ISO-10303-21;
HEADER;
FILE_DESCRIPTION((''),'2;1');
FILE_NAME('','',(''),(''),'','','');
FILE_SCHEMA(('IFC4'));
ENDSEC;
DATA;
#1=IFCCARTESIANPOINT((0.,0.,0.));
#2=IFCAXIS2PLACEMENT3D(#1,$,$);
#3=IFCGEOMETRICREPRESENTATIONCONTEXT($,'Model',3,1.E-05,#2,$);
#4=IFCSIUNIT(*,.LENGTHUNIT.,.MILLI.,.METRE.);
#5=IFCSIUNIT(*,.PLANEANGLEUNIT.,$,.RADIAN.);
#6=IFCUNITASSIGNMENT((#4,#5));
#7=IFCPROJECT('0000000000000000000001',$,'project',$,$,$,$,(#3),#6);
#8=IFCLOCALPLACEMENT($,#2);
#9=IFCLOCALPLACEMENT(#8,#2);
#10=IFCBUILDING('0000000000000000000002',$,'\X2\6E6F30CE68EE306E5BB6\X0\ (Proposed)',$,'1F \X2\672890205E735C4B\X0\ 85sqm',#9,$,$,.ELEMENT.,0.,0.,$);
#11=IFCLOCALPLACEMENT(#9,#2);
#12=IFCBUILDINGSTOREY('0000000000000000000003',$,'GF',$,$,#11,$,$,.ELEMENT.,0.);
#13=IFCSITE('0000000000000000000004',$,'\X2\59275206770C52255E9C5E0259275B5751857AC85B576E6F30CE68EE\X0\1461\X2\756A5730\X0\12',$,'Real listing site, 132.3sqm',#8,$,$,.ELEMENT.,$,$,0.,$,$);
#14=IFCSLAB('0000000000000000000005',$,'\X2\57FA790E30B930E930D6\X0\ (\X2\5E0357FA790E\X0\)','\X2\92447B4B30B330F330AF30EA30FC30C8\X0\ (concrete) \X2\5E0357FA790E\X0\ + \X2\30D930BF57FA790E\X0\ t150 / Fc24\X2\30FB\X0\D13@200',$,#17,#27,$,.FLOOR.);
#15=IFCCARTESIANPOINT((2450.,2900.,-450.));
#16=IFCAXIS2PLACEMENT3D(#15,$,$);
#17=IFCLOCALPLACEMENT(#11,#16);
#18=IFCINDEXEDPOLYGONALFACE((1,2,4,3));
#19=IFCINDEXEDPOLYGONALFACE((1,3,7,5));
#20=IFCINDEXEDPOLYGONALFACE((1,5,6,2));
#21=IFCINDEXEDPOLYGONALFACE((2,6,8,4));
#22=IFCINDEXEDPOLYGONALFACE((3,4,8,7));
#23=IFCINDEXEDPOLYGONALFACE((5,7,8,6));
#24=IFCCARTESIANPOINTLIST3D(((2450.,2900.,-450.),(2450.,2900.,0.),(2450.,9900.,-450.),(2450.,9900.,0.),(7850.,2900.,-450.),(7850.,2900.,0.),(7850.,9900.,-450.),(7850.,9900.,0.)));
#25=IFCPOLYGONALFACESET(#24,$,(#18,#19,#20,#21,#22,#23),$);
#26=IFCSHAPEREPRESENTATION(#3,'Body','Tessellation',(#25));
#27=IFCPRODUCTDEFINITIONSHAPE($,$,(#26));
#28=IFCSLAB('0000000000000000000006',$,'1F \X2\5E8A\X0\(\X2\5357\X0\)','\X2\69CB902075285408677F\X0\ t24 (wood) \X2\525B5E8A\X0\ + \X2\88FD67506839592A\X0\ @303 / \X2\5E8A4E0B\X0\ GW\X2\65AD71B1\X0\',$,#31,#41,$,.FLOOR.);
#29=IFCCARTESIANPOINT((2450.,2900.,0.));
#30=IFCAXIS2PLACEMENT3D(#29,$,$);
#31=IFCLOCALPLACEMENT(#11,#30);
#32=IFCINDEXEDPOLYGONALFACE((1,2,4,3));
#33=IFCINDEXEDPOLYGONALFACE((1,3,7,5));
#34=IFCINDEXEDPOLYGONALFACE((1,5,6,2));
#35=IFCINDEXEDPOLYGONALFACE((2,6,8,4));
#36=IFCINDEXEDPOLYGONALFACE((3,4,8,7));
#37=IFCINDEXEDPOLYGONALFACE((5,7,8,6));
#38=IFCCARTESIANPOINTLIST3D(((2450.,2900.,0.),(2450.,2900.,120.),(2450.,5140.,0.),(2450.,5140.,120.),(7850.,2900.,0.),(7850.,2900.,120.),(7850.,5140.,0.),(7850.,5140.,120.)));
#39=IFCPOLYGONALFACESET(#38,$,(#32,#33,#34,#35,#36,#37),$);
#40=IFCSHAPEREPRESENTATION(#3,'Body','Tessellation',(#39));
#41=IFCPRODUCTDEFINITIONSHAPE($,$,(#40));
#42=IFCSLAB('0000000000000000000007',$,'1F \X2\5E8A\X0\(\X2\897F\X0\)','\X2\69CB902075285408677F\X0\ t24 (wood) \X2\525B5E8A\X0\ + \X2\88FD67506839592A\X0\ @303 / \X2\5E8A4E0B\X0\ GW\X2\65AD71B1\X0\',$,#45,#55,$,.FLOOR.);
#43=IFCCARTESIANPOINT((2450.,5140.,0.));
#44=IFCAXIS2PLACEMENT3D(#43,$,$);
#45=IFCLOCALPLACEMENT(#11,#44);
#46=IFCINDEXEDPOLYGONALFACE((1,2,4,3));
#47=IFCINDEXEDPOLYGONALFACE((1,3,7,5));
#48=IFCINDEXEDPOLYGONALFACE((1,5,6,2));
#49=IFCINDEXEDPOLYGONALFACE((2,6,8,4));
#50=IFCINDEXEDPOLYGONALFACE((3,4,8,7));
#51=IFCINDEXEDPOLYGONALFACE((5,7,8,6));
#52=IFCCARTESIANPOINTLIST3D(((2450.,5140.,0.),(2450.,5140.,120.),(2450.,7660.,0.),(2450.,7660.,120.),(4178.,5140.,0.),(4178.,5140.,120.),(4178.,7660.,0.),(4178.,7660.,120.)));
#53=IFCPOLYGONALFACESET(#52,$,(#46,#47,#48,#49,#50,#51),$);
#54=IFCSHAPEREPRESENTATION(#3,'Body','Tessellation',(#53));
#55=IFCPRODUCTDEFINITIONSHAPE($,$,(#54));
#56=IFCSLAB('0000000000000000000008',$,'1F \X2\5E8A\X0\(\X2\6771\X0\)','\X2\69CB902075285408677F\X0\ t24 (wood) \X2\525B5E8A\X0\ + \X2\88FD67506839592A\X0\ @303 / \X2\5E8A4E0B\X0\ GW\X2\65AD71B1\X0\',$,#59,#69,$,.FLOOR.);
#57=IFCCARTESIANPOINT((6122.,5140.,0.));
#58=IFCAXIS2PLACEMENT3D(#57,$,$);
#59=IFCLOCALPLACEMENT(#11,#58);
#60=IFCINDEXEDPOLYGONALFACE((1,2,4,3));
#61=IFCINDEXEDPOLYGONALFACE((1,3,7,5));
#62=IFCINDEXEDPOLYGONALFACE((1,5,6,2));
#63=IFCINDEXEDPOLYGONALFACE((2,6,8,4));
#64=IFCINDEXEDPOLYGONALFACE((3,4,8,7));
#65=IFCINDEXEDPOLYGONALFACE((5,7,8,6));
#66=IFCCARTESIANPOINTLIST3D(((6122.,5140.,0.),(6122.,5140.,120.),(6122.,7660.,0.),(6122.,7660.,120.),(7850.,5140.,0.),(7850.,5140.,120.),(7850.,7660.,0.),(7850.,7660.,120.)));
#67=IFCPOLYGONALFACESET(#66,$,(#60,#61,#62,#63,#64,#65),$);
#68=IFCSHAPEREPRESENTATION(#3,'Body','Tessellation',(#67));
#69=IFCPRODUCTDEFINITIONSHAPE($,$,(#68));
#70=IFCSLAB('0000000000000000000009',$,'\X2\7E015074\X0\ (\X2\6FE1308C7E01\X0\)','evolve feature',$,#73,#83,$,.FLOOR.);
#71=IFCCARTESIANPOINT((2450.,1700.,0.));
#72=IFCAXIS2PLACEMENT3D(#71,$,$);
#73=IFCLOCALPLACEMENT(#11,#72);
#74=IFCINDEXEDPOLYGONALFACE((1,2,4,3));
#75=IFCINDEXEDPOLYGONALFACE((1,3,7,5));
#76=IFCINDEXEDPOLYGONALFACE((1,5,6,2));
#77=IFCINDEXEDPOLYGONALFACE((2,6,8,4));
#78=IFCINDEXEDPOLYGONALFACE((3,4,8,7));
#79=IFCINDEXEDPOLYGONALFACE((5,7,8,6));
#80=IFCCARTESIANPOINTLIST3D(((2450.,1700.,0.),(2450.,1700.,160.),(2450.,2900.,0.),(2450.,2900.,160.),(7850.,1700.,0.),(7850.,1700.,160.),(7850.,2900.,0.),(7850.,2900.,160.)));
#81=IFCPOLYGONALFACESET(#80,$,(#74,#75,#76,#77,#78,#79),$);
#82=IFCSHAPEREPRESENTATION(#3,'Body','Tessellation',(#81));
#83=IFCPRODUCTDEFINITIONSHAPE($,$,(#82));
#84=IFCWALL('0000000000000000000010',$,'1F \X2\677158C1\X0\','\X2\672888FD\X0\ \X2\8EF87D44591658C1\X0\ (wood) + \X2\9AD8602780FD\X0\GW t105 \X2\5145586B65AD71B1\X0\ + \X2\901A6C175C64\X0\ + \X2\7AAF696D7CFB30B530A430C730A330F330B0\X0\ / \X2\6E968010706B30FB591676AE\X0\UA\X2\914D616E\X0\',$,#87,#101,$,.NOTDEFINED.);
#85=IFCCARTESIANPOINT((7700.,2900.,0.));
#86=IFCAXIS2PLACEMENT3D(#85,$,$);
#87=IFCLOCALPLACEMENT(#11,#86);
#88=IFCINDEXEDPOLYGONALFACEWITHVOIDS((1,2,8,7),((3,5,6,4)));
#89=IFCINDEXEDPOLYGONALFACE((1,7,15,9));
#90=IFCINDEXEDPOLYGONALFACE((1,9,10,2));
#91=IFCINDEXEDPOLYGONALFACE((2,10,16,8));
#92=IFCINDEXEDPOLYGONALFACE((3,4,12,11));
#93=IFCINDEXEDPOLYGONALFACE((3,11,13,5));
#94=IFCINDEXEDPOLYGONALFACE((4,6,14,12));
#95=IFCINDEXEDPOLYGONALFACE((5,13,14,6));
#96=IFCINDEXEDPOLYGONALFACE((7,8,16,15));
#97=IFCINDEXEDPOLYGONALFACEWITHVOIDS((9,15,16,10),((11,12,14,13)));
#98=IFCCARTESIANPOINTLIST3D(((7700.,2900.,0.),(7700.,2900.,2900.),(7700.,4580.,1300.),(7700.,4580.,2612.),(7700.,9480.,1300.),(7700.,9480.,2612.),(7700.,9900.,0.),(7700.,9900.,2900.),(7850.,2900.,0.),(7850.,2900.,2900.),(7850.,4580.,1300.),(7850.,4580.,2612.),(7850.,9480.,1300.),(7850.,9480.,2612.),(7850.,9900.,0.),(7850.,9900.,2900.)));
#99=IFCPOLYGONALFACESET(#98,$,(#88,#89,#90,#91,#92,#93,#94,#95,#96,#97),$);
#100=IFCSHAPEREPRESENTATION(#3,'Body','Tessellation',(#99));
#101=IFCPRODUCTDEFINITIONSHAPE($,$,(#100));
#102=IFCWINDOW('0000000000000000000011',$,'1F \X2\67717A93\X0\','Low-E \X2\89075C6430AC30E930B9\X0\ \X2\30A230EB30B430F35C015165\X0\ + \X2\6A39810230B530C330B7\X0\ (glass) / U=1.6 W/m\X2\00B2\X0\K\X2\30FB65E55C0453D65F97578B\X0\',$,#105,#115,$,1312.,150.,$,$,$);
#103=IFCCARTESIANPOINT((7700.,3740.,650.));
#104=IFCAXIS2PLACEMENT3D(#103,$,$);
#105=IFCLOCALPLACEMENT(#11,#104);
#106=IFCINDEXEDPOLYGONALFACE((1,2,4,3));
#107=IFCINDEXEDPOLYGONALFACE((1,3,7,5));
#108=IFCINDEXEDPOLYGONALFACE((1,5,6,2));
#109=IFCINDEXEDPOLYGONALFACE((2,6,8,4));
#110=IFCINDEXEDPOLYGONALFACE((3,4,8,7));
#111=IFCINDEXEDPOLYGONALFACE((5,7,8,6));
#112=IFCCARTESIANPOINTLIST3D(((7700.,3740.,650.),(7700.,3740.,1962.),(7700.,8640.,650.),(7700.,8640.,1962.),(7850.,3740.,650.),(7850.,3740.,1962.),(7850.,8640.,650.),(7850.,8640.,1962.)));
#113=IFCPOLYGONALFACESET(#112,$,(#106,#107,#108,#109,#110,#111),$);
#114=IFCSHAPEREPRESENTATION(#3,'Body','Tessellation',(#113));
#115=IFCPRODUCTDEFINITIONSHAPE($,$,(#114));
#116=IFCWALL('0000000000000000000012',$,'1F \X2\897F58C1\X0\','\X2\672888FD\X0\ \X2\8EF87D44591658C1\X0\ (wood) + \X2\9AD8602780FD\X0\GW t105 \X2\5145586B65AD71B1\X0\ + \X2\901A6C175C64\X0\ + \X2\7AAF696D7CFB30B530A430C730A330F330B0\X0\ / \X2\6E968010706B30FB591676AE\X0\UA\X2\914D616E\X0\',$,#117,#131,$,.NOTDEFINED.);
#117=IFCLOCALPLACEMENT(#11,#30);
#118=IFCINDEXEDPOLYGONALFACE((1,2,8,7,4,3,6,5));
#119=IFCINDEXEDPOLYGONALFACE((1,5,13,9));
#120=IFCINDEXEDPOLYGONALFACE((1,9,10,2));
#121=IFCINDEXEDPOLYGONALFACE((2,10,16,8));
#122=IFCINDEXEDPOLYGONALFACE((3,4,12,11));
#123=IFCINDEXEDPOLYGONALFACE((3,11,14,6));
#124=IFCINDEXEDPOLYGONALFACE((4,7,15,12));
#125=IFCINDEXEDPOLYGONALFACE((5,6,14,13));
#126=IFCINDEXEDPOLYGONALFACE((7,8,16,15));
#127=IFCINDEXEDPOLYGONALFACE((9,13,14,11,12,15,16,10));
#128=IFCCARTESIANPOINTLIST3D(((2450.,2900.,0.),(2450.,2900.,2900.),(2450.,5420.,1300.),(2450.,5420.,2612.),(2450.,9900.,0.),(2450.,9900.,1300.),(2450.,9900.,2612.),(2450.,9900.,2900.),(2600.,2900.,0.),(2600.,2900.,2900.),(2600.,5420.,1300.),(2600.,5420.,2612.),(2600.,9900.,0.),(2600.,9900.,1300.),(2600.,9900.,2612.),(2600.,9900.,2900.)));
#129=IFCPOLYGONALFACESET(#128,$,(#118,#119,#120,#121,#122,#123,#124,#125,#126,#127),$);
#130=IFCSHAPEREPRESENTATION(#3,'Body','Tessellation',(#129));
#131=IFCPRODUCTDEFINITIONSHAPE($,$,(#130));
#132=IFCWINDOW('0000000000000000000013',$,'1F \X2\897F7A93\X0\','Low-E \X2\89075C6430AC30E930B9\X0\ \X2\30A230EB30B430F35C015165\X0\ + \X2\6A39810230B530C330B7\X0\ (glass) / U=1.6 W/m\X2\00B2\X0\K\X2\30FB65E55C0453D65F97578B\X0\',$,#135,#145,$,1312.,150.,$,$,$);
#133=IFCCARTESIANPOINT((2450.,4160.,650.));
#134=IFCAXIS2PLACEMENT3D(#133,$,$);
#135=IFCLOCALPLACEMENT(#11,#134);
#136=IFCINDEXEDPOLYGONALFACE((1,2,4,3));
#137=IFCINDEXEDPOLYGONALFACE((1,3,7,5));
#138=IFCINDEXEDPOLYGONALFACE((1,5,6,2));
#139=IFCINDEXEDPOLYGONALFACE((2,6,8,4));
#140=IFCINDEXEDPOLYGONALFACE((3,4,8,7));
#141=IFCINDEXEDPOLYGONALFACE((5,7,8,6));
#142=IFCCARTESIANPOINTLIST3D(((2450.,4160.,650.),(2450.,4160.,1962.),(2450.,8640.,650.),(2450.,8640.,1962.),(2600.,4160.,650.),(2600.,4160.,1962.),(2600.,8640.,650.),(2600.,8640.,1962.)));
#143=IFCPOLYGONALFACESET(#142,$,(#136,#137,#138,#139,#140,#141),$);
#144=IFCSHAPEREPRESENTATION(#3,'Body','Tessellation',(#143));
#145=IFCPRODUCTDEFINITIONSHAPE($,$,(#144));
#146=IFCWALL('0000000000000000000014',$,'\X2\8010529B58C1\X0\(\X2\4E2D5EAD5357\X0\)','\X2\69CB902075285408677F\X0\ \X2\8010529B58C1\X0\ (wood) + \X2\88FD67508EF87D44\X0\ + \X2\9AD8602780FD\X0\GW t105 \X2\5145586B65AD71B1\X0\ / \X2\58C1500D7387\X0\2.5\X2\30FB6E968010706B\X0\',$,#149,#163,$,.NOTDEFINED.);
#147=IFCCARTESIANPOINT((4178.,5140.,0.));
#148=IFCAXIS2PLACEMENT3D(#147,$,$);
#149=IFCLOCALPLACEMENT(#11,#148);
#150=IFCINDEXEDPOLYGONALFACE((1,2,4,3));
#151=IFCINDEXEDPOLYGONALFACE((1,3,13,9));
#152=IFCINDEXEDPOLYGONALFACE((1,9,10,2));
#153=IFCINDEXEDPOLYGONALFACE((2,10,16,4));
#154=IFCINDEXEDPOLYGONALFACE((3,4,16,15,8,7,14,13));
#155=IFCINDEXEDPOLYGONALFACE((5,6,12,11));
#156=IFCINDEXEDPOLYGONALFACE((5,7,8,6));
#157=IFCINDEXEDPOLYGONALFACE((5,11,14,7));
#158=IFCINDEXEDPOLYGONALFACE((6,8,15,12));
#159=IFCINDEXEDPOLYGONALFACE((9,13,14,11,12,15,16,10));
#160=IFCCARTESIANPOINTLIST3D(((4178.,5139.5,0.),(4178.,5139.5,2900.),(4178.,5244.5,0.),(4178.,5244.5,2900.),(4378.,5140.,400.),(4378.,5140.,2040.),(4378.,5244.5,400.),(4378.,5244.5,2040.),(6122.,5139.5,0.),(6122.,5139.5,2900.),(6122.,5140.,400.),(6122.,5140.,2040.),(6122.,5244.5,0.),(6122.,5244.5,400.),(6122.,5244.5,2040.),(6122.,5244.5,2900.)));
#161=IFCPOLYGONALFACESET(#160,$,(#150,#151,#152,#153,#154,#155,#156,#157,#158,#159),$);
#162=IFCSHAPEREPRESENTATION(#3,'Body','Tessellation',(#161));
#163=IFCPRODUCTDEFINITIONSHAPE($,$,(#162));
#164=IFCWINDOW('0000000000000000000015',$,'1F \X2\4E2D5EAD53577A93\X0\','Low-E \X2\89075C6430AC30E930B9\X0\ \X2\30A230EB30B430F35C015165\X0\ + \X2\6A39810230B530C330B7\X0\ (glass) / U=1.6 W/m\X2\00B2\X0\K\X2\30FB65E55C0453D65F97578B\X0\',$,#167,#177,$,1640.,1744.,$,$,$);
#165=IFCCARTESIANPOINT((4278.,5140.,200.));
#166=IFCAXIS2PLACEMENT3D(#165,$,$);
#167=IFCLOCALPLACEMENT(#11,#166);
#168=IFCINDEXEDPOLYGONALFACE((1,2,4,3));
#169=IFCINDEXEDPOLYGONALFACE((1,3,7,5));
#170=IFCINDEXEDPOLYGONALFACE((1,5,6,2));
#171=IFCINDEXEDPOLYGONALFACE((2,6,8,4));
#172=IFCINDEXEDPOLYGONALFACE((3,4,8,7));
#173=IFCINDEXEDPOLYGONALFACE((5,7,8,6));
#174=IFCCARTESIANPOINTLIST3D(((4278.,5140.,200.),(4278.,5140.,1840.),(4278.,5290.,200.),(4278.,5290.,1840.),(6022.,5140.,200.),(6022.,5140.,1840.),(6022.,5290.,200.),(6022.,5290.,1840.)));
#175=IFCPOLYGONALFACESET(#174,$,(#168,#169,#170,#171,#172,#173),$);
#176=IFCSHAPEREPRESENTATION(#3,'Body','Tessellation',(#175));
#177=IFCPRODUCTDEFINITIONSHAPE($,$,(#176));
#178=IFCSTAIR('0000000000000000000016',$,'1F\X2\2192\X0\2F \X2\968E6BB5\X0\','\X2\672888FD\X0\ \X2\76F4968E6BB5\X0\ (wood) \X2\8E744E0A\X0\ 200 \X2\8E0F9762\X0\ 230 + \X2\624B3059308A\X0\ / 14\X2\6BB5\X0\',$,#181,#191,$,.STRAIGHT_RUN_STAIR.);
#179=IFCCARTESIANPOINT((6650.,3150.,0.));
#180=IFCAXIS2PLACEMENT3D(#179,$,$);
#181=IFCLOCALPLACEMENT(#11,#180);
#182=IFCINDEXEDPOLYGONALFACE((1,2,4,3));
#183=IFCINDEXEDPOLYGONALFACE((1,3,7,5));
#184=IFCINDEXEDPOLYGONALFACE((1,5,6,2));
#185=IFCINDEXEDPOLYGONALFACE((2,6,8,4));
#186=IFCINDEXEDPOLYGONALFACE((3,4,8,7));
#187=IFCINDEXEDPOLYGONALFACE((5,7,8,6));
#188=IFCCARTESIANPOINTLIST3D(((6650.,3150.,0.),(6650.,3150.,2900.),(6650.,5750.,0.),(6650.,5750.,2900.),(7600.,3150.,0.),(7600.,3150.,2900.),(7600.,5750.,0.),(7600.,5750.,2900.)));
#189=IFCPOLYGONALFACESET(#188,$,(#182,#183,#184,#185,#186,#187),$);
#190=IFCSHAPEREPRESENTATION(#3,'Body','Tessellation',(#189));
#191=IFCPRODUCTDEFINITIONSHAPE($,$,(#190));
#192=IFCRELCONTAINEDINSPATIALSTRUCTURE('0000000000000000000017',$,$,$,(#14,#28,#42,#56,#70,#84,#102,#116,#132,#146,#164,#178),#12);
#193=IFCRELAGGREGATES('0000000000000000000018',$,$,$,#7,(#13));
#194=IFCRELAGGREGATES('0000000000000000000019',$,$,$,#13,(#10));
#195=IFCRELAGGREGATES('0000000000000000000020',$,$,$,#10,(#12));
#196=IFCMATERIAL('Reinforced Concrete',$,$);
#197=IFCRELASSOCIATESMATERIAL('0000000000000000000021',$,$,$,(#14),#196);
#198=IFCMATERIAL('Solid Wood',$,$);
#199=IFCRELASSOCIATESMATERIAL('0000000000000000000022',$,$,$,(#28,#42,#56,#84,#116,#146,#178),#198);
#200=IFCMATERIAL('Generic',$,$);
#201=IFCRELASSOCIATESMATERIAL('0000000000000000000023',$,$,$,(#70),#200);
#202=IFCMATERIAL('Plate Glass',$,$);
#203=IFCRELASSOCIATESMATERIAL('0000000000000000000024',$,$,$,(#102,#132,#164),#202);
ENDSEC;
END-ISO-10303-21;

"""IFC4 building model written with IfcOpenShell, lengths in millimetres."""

from ifc_helpers import new_model, si_unit, frame, frame_2d, origin, place, context, project, spatial, rectangle, extrude, material, element, fill, save


model = new_model("IFC4")

# Units and contexts
model_context = context("Model", 3, precision=1e-05, world=origin())
ifc_project = project(units=[si_unit("LENGTHUNIT", "METRE", prefix="MILLI"), si_unit("PLANEANGLEUNIT", "RADIAN")], contexts=[model_context])

# Site, building, storey
site_placement = place(None, origin())
site = spatial("IfcSite", under=ifc_project, at=site_placement, Name="大分県別府市大字内竈字湯ノ森1461番地12", ObjectType="Real listing site, 132.3sqm", CompositionType="ELEMENT", RefElevation=0.0)
building_placement = place(site_placement, origin())
building = spatial("IfcBuilding", under=site, at=building_placement, Name="湯ノ森の家 (Proposed)", ObjectType="1F 木造平屋 85sqm", CompositionType="ELEMENT", ElevationOfRefHeight=0.0, ElevationOfTerrain=0.0)
storey_placement = place(building_placement, origin())
storey = spatial("IfcBuildingStorey", under=building, at=storey_placement, Name="GF", CompositionType="ELEMENT", Elevation=0.0)

# Slabs
ifc_material_1 = material(Name="Reinforced Concrete")
slab_1_placement = place(storey_placement, frame((2450.0, 2900.0, -450.0)))
element("IfcSlab", 1, at=slab_1_placement, inside=storey, material=ifc_material_1, Name="基礎スラブ (布基礎)", Description="鉄筋コンクリート (concrete) 布基礎 + ベタ基礎 t150 / Fc24・D13@200", PredefinedType="FLOOR", context=model_context, shape_type="SweptSolid", body=[
    extrude(rectangle(XDim=5400.0, YDim=7000.0, at=frame_2d((2700.0, 3500.0))), frame((2450.0, 2900.0, -450.0)), (0.0, 0.0, 1.0), 450.0),
])
ifc_material_2 = material(Name="Solid Wood")
slab_2_placement = place(storey_placement, frame((2450.0, 2900.0, 0.0)))
element("IfcSlab", 2, at=slab_2_placement, inside=storey, material=ifc_material_2, Name="1F 床(南)", Description="構造用合板 t24 (wood) 剛床 + 製材根太 @303 / 床下 GW断熱", PredefinedType="FLOOR", context=model_context, shape_type="SweptSolid", body=[
    extrude(rectangle(XDim=5400.0, YDim=2240.0, at=frame_2d((2700.0, 1120.0))), frame((2450.0, 2900.0, 0.0)), (0.0, 0.0, 1.0), 120.0),
])
slab_3_placement = place(storey_placement, frame((2450.0, 5140.0, 0.0)))
element("IfcSlab", 3, at=slab_3_placement, inside=storey, material=ifc_material_2, Name="1F 床(西)", Description="構造用合板 t24 (wood) 剛床 + 製材根太 @303 / 床下 GW断熱", PredefinedType="FLOOR", context=model_context, shape_type="SweptSolid", body=[
    extrude(rectangle(XDim=1728.0, YDim=2520.0, at=frame_2d((864.0, 1260.0))), frame((2450.0, 5140.0, 0.0)), (0.0, 0.0, 1.0), 120.0),
])
slab_4_placement = place(storey_placement, frame((6122.0, 5140.0, 0.0)))
element("IfcSlab", 4, at=slab_4_placement, inside=storey, material=ifc_material_2, Name="1F 床(東)", Description="構造用合板 t24 (wood) 剛床 + 製材根太 @303 / 床下 GW断熱", PredefinedType="FLOOR", context=model_context, shape_type="SweptSolid", body=[
    extrude(rectangle(XDim=1728.0, YDim=2520.0, at=frame_2d((864.0, 1260.0))), frame((6122.0, 5140.0, 0.0)), (0.0, 0.0, 1.0), 120.0),
])
ifc_material_3 = material(Name="Generic")
slab_5_placement = place(storey_placement, frame((2450.0, 1700.0, 0.0)))
element("IfcSlab", 5, at=slab_5_placement, inside=storey, material=ifc_material_3, Name="縁側 (濡れ縁)", Description="evolve feature", PredefinedType="FLOOR", context=model_context, shape_type="SweptSolid", body=[
    extrude(rectangle(XDim=5400.0, YDim=1200.0, at=frame_2d((2700.0, 600.0))), frame((2450.0, 1700.0, 0.0)), (0.0, 0.0, 1.0), 160.0),
])

# Shared definitions
ifc_material_4 = material(Name="Plate Glass")

# Walls, openings, windows
wall_1_placement = place(storey_placement, frame((7700.0, 2900.0, 0.0)))
wall_1 = element("IfcWall", 6, at=wall_1_placement, inside=storey, material=ifc_material_2, Name="1F 東壁", Description="木製 軸組外壁 (wood) + 高性能GW t105 充填断熱 + 通気層 + 窯業系サイディング / 準耐火・外皮UA配慮", PredefinedType="NOTDEFINED", context=model_context, shape_type="SweptSolid", body=[
    extrude(rectangle(XDim=150.0, YDim=7000.0, at=frame_2d((75.0, 3500.0))), frame((7700.0, 2900.0, 0.0)), (0.0, 0.0, 1.0), 2900.0),
])
opening_1_placement = place(storey_placement, frame((7700.0, 3740.0, 650.0)))
opening_1 = element("IfcOpeningElement", 7, at=opening_1_placement, cuts=wall_1, PredefinedType="NOTDEFINED", context=model_context, shape_type="SweptSolid", body=[
    extrude(rectangle(XDim=150.0, YDim=4900.0, at=frame_2d((75.0, 2450.0))), frame((7700.0, 3740.0, 650.0)), (0.0, 0.0, 1.0), 1312.0),
])
window_1_placement = place(storey_placement, frame((7700.0, 3740.0, 650.0)))
window_1 = element("IfcWindow", 8, at=window_1_placement, inside=storey, material=ifc_material_4, Name="1F 東窓", Description="Low-E 複層ガラス アルゴン封入 + 樹脂サッシ (glass) / U=1.6 W/m²K・日射取得型", OverallHeight=1312.0, OverallWidth=150.0, context=model_context, shape_type="SweptSolid", body=[
    extrude(rectangle(XDim=150.0, YDim=4900.0, at=frame_2d((75.0, 2450.0))), frame((7700.0, 3740.0, 650.0)), (0.0, 0.0, 1.0), 1312.0),
])
fill(opening_1, window_1)
wall_2_placement = place(storey_placement, frame((2450.0, 2900.0, 0.0)))
wall_2 = element("IfcWall", 9, at=wall_2_placement, inside=storey, material=ifc_material_2, Name="1F 西壁", Description="木製 軸組外壁 (wood) + 高性能GW t105 充填断熱 + 通気層 + 窯業系サイディング / 準耐火・外皮UA配慮", PredefinedType="NOTDEFINED", context=model_context, shape_type="SweptSolid", body=[
    extrude(rectangle(XDim=150.0, YDim=7000.0, at=frame_2d((75.0, 3500.0))), frame((2450.0, 2900.0, 0.0)), (0.0, 0.0, 1.0), 2900.0),
])
opening_2_placement = place(storey_placement, frame((2450.0, 4160.0, 650.0)))
opening_2 = element("IfcOpeningElement", 10, at=opening_2_placement, cuts=wall_2, PredefinedType="NOTDEFINED", context=model_context, shape_type="SweptSolid", body=[
    extrude(rectangle(XDim=150.0, YDim=4480.0, at=frame_2d((75.0, 2240.0))), frame((2450.0, 4160.0, 650.0)), (0.0, 0.0, 1.0), 1312.0),
])
window_2_placement = place(storey_placement, frame((2450.0, 4160.0, 650.0)))
window_2 = element("IfcWindow", 11, at=window_2_placement, inside=storey, material=ifc_material_4, Name="1F 西窓", Description="Low-E 複層ガラス アルゴン封入 + 樹脂サッシ (glass) / U=1.6 W/m²K・日射取得型", OverallHeight=1312.0, OverallWidth=150.0, context=model_context, shape_type="SweptSolid", body=[
    extrude(rectangle(XDim=150.0, YDim=4480.0, at=frame_2d((75.0, 2240.0))), frame((2450.0, 4160.0, 650.0)), (0.0, 0.0, 1.0), 1312.0),
])
fill(opening_2, window_2)
wall_3_placement = place(storey_placement, frame((4178.0, 5140.0, 0.0)))
wall_3 = element("IfcWall", 12, at=wall_3_placement, inside=storey, material=ifc_material_2, Name="耐力壁(中庭南)", Description="構造用合板 耐力壁 (wood) + 製材軸組 + 高性能GW t105 充填断熱 / 壁倍率2.5・準耐火", PredefinedType="NOTDEFINED", context=model_context, shape_type="SweptSolid", body=[
    extrude(rectangle(XDim=1944.0, YDim=105.0, at=frame_2d((972.0, 52.0))), frame((4178.0, 5140.0, 0.0)), (0.0, 0.0, 1.0), 2900.0),
])
opening_3_placement = place(storey_placement, frame((4278.0, 5140.0, 200.0)))
opening_3 = element("IfcOpeningElement", 13, at=opening_3_placement, cuts=wall_3, PredefinedType="NOTDEFINED", context=model_context, shape_type="SweptSolid", body=[
    extrude(rectangle(XDim=1744.0, YDim=150.0, at=frame_2d((872.0, 75.0))), frame((4278.0, 5140.0, 200.0)), (0.0, 0.0, 1.0), 1640.0),
])
window_3_placement = place(storey_placement, frame((4278.0, 5140.0, 200.0)))
window_3 = element("IfcWindow", 14, at=window_3_placement, inside=storey, material=ifc_material_4, Name="1F 中庭南窓", Description="Low-E 複層ガラス アルゴン封入 + 樹脂サッシ (glass) / U=1.6 W/m²K・日射取得型", OverallHeight=1640.0, OverallWidth=1744.0, context=model_context, shape_type="SweptSolid", body=[
    extrude(rectangle(XDim=1744.0, YDim=150.0, at=frame_2d((872.0, 75.0))), frame((4278.0, 5140.0, 200.0)), (0.0, 0.0, 1.0), 1640.0),
])
fill(opening_3, window_3)

# Stair
stair_placement = place(storey_placement, frame((6650.0, 3150.0, 0.0)))
element("IfcStair", 15, at=stair_placement, inside=storey, material=ifc_material_2, Name="1F→2F 階段", Description="木製 直階段 (wood) 蹴上 200 踏面 230 + 手すり / 14段", PredefinedType="STRAIGHT_RUN_STAIR", context=model_context, shape_type="SweptSolid", body=[
    extrude(rectangle(XDim=950.0, YDim=2600.0, at=frame_2d((475.0, 1300.0))), frame((6650.0, 3150.0, 0.0)), (0.0, 0.0, 1.0), 2900.0),
])

save(model, "model.ifc")
